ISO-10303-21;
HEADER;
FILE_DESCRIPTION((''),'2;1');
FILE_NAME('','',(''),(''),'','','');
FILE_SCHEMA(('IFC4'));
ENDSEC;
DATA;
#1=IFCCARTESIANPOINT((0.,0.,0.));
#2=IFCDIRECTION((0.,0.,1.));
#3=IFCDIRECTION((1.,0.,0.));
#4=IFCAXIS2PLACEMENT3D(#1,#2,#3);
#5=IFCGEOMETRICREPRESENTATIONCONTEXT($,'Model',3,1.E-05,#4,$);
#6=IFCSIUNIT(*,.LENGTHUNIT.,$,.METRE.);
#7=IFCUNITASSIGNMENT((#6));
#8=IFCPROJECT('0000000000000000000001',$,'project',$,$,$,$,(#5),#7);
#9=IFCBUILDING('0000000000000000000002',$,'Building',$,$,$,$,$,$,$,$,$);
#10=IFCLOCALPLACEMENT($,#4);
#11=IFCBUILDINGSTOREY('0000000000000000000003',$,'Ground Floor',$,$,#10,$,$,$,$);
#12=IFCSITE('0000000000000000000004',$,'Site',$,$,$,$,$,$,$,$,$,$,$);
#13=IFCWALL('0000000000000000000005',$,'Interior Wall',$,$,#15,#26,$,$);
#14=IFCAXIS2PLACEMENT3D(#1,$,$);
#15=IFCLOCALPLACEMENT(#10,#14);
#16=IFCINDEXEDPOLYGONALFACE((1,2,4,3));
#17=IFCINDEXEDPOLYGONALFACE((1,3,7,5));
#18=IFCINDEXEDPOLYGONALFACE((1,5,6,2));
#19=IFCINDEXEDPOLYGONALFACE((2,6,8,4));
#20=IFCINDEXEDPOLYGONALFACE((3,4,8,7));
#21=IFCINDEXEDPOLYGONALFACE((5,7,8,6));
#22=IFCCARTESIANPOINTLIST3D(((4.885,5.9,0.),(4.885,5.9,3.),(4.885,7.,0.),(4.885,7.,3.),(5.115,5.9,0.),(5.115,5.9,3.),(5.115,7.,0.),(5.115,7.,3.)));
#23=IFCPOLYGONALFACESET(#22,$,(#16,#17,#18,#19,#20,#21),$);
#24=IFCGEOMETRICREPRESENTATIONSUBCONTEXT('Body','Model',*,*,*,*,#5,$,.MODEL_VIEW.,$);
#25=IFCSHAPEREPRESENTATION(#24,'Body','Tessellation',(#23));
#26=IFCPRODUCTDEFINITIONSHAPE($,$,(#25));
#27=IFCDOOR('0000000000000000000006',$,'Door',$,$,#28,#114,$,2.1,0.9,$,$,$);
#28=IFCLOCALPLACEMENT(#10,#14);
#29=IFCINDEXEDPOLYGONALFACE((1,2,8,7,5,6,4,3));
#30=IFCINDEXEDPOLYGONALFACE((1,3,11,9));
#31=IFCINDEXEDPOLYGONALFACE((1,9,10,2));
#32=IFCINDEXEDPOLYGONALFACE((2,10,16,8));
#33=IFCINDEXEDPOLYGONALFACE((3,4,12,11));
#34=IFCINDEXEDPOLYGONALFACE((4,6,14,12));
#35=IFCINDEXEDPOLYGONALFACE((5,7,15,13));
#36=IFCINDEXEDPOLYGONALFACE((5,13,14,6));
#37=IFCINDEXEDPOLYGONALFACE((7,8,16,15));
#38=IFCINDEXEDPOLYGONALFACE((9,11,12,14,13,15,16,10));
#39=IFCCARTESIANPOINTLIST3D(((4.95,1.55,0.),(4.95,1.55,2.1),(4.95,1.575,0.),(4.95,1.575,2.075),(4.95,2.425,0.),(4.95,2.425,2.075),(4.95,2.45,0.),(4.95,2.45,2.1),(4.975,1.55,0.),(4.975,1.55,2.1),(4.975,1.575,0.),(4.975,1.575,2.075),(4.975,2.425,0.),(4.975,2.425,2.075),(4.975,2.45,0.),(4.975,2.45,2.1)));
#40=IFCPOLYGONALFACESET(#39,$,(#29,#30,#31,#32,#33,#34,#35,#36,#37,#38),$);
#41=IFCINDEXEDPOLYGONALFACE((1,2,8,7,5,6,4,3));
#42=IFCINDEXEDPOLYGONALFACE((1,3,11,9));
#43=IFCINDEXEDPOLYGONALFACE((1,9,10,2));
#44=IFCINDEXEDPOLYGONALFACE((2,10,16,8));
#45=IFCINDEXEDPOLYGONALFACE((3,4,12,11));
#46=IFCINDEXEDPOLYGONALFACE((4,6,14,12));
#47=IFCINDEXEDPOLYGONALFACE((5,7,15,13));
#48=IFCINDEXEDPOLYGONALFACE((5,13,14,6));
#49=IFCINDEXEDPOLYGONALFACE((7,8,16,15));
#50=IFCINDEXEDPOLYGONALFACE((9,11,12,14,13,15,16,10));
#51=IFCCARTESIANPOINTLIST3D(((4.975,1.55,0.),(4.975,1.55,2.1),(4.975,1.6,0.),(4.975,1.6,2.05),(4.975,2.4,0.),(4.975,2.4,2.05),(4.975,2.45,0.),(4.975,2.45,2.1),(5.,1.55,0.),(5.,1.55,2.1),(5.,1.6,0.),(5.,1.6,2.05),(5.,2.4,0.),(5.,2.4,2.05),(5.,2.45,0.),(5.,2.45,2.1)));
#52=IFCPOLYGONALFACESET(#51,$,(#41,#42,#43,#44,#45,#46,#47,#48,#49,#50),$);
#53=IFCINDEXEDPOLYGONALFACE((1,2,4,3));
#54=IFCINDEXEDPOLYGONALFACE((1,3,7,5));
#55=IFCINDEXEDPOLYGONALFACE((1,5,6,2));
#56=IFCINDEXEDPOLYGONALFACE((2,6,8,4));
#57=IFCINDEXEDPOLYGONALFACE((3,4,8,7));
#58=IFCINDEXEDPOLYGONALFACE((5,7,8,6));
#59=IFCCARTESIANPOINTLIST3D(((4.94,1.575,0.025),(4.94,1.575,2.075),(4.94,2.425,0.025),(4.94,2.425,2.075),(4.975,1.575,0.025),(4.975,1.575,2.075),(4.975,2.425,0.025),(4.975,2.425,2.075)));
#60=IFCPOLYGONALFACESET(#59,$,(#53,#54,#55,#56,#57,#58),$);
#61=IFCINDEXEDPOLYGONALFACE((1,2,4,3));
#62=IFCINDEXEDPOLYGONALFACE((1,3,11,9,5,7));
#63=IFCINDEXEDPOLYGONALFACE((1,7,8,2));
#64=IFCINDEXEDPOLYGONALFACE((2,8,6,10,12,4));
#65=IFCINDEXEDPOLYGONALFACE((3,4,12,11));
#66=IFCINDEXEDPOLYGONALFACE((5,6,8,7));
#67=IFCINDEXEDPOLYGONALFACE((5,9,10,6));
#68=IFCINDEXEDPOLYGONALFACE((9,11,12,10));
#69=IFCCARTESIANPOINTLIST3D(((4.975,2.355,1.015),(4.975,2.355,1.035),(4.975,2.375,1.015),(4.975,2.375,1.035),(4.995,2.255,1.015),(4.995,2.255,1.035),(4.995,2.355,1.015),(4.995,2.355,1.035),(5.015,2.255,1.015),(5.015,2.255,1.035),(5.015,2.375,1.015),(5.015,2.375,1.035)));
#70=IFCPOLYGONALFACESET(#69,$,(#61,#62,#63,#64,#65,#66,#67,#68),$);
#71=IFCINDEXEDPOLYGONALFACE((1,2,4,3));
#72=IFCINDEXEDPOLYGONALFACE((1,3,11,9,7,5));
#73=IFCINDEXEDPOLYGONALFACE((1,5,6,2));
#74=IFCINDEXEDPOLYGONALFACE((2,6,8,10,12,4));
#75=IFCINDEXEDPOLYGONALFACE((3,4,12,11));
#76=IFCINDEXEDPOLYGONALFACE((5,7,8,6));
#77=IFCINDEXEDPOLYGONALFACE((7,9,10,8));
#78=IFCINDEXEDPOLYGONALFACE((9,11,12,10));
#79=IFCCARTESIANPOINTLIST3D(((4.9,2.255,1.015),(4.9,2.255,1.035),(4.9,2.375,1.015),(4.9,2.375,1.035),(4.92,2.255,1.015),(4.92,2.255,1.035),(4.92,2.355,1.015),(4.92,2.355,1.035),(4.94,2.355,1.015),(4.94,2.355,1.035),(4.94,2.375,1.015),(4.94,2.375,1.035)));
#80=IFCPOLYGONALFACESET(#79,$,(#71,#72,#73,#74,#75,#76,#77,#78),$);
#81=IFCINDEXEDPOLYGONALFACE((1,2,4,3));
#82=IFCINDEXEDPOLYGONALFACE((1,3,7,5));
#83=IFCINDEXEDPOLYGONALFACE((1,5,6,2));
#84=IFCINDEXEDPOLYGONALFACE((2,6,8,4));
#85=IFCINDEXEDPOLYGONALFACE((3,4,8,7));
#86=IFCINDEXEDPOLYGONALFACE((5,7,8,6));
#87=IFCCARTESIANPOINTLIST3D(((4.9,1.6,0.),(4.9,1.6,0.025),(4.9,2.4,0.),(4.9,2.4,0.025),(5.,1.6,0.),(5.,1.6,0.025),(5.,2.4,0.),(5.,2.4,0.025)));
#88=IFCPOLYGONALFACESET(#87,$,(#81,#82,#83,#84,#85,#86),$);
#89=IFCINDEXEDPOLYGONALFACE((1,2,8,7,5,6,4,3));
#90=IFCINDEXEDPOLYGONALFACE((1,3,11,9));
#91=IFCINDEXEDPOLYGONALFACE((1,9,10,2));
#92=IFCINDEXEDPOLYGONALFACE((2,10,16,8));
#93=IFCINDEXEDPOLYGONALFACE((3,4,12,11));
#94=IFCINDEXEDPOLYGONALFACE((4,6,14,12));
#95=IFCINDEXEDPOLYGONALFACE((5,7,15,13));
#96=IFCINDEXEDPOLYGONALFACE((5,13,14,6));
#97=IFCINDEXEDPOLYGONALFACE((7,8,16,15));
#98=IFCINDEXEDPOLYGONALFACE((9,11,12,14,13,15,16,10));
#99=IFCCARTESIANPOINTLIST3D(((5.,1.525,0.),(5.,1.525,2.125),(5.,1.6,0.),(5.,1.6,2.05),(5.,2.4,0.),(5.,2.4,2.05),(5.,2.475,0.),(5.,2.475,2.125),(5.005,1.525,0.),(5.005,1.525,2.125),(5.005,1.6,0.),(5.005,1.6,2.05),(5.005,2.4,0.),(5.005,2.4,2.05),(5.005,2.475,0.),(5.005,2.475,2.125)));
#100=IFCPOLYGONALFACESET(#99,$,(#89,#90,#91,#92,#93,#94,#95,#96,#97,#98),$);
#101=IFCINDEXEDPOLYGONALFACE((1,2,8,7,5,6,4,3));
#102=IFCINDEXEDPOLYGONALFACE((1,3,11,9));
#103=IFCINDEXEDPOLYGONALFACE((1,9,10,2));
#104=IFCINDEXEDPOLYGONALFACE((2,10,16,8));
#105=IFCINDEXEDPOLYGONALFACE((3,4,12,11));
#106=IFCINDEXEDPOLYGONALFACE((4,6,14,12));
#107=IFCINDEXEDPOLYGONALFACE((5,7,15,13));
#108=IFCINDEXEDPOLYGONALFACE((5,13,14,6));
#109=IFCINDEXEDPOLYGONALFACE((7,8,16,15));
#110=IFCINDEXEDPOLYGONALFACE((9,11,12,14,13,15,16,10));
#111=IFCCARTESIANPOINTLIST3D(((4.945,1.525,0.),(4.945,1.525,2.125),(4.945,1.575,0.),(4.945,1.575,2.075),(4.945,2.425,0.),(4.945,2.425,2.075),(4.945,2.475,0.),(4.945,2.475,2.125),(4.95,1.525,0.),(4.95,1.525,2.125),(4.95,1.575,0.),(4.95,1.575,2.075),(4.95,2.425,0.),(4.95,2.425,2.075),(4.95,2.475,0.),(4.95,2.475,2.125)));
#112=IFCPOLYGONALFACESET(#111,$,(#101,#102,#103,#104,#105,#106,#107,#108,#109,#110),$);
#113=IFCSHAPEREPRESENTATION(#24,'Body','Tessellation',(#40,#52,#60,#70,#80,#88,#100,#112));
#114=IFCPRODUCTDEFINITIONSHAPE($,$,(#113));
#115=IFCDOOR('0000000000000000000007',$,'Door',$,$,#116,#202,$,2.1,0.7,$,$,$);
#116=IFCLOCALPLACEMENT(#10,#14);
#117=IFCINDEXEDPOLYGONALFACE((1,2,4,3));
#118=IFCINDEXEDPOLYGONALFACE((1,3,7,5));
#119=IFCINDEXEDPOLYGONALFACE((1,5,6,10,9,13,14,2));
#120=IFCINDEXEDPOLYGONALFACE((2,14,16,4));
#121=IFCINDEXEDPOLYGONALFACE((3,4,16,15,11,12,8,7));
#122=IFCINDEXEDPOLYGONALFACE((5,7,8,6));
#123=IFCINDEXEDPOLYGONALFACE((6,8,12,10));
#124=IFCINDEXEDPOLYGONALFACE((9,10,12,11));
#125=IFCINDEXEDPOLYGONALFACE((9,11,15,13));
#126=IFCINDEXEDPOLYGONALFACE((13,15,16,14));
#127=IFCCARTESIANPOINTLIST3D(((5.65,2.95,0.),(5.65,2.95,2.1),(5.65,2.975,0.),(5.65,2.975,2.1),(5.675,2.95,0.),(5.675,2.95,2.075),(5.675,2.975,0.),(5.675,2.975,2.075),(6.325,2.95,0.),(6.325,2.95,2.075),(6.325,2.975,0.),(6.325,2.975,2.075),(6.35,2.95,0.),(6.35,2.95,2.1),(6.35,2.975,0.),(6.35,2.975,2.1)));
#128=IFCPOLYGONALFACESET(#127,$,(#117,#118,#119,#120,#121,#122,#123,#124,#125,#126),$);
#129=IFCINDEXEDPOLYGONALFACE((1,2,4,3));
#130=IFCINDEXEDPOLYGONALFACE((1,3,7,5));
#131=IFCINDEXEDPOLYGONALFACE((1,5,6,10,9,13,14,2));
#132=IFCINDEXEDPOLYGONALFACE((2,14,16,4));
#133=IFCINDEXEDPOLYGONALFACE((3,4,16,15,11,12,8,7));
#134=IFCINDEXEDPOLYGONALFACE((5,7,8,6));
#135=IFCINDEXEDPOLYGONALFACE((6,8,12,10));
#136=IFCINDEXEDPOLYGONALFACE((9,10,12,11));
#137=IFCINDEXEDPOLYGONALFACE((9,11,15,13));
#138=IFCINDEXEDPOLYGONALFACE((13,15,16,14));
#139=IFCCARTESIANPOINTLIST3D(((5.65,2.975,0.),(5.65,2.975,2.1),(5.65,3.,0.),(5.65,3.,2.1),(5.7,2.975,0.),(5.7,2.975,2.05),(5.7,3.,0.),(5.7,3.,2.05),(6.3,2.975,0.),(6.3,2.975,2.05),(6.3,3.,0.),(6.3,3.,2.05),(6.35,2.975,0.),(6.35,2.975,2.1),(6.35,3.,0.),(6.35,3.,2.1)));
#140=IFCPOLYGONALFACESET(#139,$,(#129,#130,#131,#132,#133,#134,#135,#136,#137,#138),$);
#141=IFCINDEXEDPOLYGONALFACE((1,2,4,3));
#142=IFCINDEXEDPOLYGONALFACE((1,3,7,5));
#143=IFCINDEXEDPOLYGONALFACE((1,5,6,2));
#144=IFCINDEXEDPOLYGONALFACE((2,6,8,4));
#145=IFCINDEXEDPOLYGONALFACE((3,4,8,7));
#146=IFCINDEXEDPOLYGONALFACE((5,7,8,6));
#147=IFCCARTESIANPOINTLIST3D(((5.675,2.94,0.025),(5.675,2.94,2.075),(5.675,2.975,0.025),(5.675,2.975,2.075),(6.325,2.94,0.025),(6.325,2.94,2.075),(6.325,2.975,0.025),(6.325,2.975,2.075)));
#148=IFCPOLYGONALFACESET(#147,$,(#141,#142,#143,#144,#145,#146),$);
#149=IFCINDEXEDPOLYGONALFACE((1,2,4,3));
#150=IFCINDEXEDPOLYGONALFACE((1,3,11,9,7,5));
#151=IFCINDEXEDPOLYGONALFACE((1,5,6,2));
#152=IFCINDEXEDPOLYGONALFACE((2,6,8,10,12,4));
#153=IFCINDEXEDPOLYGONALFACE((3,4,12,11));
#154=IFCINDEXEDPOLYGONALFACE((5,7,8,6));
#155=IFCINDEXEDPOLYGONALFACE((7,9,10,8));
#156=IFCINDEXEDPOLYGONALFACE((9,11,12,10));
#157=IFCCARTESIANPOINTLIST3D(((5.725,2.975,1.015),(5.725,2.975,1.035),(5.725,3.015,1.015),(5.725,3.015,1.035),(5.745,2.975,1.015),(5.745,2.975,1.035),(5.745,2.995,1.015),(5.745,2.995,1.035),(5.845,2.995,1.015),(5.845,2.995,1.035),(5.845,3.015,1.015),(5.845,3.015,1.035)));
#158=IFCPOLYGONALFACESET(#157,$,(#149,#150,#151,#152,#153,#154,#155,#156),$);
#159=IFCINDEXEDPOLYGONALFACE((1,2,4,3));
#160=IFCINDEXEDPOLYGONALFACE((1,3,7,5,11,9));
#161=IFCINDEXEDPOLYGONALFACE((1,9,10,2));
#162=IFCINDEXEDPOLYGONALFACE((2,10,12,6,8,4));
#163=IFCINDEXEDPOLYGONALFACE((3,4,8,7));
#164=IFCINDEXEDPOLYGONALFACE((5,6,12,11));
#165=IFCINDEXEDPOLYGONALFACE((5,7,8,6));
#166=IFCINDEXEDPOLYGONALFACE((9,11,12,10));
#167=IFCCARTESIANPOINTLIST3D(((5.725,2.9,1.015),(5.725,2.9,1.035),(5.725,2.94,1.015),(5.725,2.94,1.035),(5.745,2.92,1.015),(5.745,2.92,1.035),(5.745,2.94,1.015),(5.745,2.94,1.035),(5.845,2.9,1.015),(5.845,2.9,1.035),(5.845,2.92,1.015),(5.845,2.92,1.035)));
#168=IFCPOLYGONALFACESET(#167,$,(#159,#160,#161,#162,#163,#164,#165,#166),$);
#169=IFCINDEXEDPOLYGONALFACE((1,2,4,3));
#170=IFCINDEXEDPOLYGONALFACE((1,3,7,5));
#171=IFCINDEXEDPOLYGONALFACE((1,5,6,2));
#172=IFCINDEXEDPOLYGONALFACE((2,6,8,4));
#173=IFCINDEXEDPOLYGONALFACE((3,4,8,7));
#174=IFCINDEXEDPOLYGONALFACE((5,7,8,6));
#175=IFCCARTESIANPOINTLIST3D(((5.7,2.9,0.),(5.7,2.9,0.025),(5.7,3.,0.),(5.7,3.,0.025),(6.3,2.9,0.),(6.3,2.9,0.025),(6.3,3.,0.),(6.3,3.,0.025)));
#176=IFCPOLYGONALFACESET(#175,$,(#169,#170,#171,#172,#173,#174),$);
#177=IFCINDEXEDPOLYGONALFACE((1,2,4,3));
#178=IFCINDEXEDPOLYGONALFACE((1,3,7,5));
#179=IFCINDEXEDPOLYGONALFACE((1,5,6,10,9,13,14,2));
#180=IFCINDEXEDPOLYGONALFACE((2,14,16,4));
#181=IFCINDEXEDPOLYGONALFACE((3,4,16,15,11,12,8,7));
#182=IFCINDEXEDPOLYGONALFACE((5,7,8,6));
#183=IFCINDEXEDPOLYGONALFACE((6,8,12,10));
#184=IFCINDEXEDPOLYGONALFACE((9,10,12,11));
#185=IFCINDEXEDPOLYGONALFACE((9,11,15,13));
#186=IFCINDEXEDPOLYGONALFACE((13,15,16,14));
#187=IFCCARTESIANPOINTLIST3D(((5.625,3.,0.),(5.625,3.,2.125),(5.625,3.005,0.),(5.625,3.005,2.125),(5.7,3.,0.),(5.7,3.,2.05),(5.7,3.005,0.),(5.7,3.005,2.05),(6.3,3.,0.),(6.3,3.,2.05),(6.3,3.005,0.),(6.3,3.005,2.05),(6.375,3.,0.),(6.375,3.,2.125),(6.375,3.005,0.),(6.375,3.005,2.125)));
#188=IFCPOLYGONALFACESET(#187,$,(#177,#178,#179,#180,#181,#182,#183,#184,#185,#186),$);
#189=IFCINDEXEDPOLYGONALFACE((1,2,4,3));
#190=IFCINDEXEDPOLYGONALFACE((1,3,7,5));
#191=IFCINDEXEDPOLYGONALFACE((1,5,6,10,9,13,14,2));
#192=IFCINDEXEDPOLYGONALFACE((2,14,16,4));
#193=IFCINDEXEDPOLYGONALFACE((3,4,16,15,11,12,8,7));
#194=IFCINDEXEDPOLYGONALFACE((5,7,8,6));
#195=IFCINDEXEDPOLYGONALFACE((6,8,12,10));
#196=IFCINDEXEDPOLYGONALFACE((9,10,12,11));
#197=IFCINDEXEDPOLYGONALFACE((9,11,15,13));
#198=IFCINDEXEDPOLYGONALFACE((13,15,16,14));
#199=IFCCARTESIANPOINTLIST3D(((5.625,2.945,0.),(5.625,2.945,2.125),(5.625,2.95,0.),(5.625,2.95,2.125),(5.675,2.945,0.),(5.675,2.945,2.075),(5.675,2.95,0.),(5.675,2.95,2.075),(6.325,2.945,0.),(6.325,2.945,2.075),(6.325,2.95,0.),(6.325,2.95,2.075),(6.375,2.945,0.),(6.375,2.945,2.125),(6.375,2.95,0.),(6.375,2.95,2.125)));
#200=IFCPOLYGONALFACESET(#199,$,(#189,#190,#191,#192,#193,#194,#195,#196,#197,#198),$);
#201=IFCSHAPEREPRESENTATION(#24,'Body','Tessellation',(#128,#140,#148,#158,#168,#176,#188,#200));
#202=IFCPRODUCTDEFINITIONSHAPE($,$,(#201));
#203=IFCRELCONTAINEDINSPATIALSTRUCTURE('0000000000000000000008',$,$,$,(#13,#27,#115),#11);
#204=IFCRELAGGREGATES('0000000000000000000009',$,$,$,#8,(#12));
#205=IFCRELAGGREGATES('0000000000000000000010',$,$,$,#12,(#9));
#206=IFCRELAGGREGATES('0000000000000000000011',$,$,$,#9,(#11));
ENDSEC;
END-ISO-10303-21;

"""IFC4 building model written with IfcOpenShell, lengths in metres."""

from ifc_helpers import new_model, si_unit, frame, origin_with_axes, place, context, subcontext, project, spatial, line, indexed_curve, outline, extrude, element, save


model = new_model("IFC4")

# Units and contexts
model_context = context("Model", 3, precision=1e-05, world=origin_with_axes())
body_context = subcontext(model_context, "Body", "Model", "MODEL_VIEW")
ifc_project = project(units=[si_unit("LENGTHUNIT", "METRE")], contexts=[model_context])

# Site, building, storey
site = spatial("IfcSite", under=ifc_project, Name="Site")
building = spatial("IfcBuilding", under=site, Name="Building")
storey_placement = place(None, origin_with_axes())
storey = spatial("IfcBuildingStorey", under=building, at=storey_placement, Name="Ground Floor")

# Wall
wall_1_placement = place(storey_placement, frame((5.0, 5.9, 0.0), z_axis=(0.0, 0.0, 1.0), x_axis=(0.0, 1.0, 0.0)))
element("IfcWall", 1, at=wall_1_placement, inside=storey, Name="Interior Wall", context=body_context, shape_type="SweptSolid", body=[
    extrude(outline(indexed_curve([(0.0, 0.0), (0.0, 0.23), (1.1, 0.23), (1.1, 0.0), (0.0, 0.0)], self_intersect=False)), frame((0.0, -0.115, 0.0), z_axis=(0.0, 0.0, 1.0), x_axis=(1.0, 0.0, 0.0)), (0.0, 0.0, 1.0), 3.0),
])

# Doors
door_1_placement = place(storey_placement, frame((5.0, 1.55, 0.0), z_axis=(0.0, 0.0, 1.0), x_axis=(0.0, 1.0, 0.0)))
element("IfcDoor", 2, at=door_1_placement, inside=storey, Name="Door", OverallHeight=2.1, OverallWidth=0.9, context=body_context, shape_type="SweptSolid", body=[
    extrude(outline(indexed_curve([(0.0, 0.0), (0.0, 2.1), (0.9, 2.1), (0.9, 0.0), (0.875, 0.0), (0.875, 2.075), (0.025, 2.075), (0.025, 0.0)], segments=[line(1, 2, 3, 4, 5, 6, 7, 8, 1)])), frame((0.0, 0.025, 0.0), z_axis=(0.0, -1.0, 0.0), x_axis=(1.0, 0.0, 0.0)), (0.0, 0.0, -1.0), 0.025),
    extrude(outline(indexed_curve([(0.0, 0.0), (0.0, 2.1), (0.9, 2.1), (0.9, 0.0), (0.85, 0.0), (0.85, 2.05), (0.05, 2.05), (0.05, 0.0)], segments=[line(1, 2, 3, 4, 5, 6, 7, 8, 1)])), frame((0.0, 0.0, 0.0), z_axis=(0.0, -1.0, 0.0), x_axis=(1.0, 0.0, 0.0)), (0.0, 0.0, -1.0), 0.025),
    extrude(outline(indexed_curve([(0.0, 0.0), (0.85, 0.0), (0.85, 0.035), (0.0, 0.035)], segments=[line(1, 2, 3, 4, 1)])), frame((0.025, 0.025, 0.025), z_axis=(0.0, 0.0, 1.0), x_axis=(1.0, 0.0, 0.0)), (0.0, 0.0, 1.0), 2.05),
    extrude(outline(indexed_curve([(0.0, 0.0), (0.0, -0.04), (-0.12, -0.04), (-0.12, -0.02), (-0.02, -0.02), (-0.02, 0.0)], segments=[line(1, 2, 3, 4, 5, 6, 1)])), frame((0.825, 0.025, 1.015), z_axis=(0.0, 0.0, 1.0), x_axis=(1.0, 0.0, 0.0)), (0.0, 0.0, 1.0), 0.02),
    extrude(outline(indexed_curve([(0.0, 0.0), (0.0, 0.04), (-0.12, 0.04), (-0.12, 0.02), (-0.02, 0.02), (-0.02, 0.0)], segments=[line(1, 2, 3, 4, 5, 6, 1)])), frame((0.825, 0.06, 1.015), z_axis=(0.0, 0.0, 1.0), x_axis=(1.0, 0.0, 0.0)), (0.0, 0.0, 1.0), 0.02),
    extrude(outline(indexed_curve([(0.0, 0.0), (0.8, 0.0), (0.8, 0.1), (0.0, 0.1)], segments=[line(1, 2, 3, 4, 1)])), frame((0.05, 0.0, 0.0), z_axis=(0.0, 0.0, 1.0), x_axis=(1.0, 0.0, 0.0)), (0.0, 0.0, 1.0), 0.025),
    extrude(outline(indexed_curve([(0.0, 0.0), (0.0, 2.125), (0.95, 2.125), (0.95, 0.0), (0.875, 0.0), (0.875, 2.05), (0.075, 2.05), (0.075, 0.0)], segments=[line(1, 2, 3, 4, 5, 6, 7, 8, 1)])), frame((-0.025, -0.005, 0.0), z_axis=(0.0, -1.0, 0.0), x_axis=(1.0, 0.0, 0.0)), (0.0, 0.0, -1.0), 0.005),
    extrude(outline(indexed_curve([(0.0, 0.0), (0.0, 2.125), (0.95, 2.125), (0.95, 0.0), (0.9, 0.0), (0.9, 2.075), (0.05, 2.075), (0.05, 0.0)], segments=[line(1, 2, 3, 4, 5, 6, 7, 8, 1)])), frame((-0.025, 0.05, 0.0), z_axis=(0.0, -1.0, 0.0), x_axis=(1.0, 0.0, 0.0)), (0.0, 0.0, -1.0), 0.005),
])
door_2_placement = place(storey_placement, frame((6.35, 3.0, 0.0), z_axis=(0.0, 0.0, 1.0), x_axis=(-1.0, 0.0, 0.0)))
element("IfcDoor", 3, at=door_2_placement, inside=storey, Name="Door", OverallHeight=2.1, OverallWidth=0.7, context=body_context, shape_type="SweptSolid", body=[
    extrude(outline(indexed_curve([(0.0, 0.0), (0.0, 2.1), (0.7, 2.1), (0.7, 0.0), (0.675, 0.0), (0.675, 2.075), (0.025, 2.075), (0.025, 0.0)], segments=[line(1, 2, 3, 4, 5, 6, 7, 8, 1)])), frame((0.0, 0.025, 0.0), z_axis=(0.0, -1.0, 0.0), x_axis=(1.0, 0.0, 0.0)), (0.0, 0.0, -1.0), 0.025),
    extrude(outline(indexed_curve([(0.0, 0.0), (0.0, 2.1), (0.7, 2.1), (0.7, 0.0), (0.65, 0.0), (0.65, 2.05), (0.05, 2.05), (0.05, 0.0)], segments=[line(1, 2, 3, 4, 5, 6, 7, 8, 1)])), frame((0.0, 0.0, 0.0), z_axis=(0.0, -1.0, 0.0), x_axis=(1.0, 0.0, 0.0)), (0.0, 0.0, -1.0), 0.025),
    extrude(outline(indexed_curve([(0.0, 0.0), (0.65, 0.0), (0.65, 0.035), (0.0, 0.035)], segments=[line(1, 2, 3, 4, 1)])), frame((0.025, 0.025, 0.025), z_axis=(0.0, 0.0, 1.0), x_axis=(1.0, 0.0, 0.0)), (0.0, 0.0, 1.0), 2.05),
    extrude(outline(indexed_curve([(0.0, 0.0), (0.0, -0.04), (-0.12, -0.04), (-0.12, -0.02), (-0.02, -0.02), (-0.02, 0.0)], segments=[line(1, 2, 3, 4, 5, 6, 1)])), frame((0.625, 0.025, 1.015), z_axis=(0.0, 0.0, 1.0), x_axis=(1.0, 0.0, 0.0)), (0.0, 0.0, 1.0), 0.02),
    extrude(outline(indexed_curve([(0.0, 0.0), (0.0, 0.04), (-0.12, 0.04), (-0.12, 0.02), (-0.02, 0.02), (-0.02, 0.0)], segments=[line(1, 2, 3, 4, 5, 6, 1)])), frame((0.625, 0.06, 1.015), z_axis=(0.0, 0.0, 1.0), x_axis=(1.0, 0.0, 0.0)), (0.0, 0.0, 1.0), 0.02),
    extrude(outline(indexed_curve([(0.0, 0.0), (0.6, 0.0), (0.6, 0.1), (0.0, 0.1)], segments=[line(1, 2, 3, 4, 1)])), frame((0.05, 0.0, 0.0), z_axis=(0.0, 0.0, 1.0), x_axis=(1.0, 0.0, 0.0)), (0.0, 0.0, 1.0), 0.025),
    extrude(outline(indexed_curve([(0.0, 0.0), (0.0, 2.125), (0.75, 2.125), (0.75, 0.0), (0.675, 0.0), (0.675, 2.05), (0.075, 2.05), (0.075, 0.0)], segments=[line(1, 2, 3, 4, 5, 6, 7, 8, 1)])), frame((-0.025, -0.005, 0.0), z_axis=(0.0, -1.0, 0.0), x_axis=(1.0, 0.0, 0.0)), (0.0, 0.0, -1.0), 0.005),
    extrude(outline(indexed_curve([(0.0, 0.0), (0.0, 2.125), (0.75, 2.125), (0.75, 0.0), (0.7, 0.0), (0.7, 2.075), (0.05, 2.075), (0.05, 0.0)], segments=[line(1, 2, 3, 4, 5, 6, 7, 8, 1)])), frame((-0.025, 0.05, 0.0), z_axis=(0.0, -1.0, 0.0), x_axis=(1.0, 0.0, 0.0)), (0.0, 0.0, -1.0), 0.005),
])

save(model, "model.ifc")
